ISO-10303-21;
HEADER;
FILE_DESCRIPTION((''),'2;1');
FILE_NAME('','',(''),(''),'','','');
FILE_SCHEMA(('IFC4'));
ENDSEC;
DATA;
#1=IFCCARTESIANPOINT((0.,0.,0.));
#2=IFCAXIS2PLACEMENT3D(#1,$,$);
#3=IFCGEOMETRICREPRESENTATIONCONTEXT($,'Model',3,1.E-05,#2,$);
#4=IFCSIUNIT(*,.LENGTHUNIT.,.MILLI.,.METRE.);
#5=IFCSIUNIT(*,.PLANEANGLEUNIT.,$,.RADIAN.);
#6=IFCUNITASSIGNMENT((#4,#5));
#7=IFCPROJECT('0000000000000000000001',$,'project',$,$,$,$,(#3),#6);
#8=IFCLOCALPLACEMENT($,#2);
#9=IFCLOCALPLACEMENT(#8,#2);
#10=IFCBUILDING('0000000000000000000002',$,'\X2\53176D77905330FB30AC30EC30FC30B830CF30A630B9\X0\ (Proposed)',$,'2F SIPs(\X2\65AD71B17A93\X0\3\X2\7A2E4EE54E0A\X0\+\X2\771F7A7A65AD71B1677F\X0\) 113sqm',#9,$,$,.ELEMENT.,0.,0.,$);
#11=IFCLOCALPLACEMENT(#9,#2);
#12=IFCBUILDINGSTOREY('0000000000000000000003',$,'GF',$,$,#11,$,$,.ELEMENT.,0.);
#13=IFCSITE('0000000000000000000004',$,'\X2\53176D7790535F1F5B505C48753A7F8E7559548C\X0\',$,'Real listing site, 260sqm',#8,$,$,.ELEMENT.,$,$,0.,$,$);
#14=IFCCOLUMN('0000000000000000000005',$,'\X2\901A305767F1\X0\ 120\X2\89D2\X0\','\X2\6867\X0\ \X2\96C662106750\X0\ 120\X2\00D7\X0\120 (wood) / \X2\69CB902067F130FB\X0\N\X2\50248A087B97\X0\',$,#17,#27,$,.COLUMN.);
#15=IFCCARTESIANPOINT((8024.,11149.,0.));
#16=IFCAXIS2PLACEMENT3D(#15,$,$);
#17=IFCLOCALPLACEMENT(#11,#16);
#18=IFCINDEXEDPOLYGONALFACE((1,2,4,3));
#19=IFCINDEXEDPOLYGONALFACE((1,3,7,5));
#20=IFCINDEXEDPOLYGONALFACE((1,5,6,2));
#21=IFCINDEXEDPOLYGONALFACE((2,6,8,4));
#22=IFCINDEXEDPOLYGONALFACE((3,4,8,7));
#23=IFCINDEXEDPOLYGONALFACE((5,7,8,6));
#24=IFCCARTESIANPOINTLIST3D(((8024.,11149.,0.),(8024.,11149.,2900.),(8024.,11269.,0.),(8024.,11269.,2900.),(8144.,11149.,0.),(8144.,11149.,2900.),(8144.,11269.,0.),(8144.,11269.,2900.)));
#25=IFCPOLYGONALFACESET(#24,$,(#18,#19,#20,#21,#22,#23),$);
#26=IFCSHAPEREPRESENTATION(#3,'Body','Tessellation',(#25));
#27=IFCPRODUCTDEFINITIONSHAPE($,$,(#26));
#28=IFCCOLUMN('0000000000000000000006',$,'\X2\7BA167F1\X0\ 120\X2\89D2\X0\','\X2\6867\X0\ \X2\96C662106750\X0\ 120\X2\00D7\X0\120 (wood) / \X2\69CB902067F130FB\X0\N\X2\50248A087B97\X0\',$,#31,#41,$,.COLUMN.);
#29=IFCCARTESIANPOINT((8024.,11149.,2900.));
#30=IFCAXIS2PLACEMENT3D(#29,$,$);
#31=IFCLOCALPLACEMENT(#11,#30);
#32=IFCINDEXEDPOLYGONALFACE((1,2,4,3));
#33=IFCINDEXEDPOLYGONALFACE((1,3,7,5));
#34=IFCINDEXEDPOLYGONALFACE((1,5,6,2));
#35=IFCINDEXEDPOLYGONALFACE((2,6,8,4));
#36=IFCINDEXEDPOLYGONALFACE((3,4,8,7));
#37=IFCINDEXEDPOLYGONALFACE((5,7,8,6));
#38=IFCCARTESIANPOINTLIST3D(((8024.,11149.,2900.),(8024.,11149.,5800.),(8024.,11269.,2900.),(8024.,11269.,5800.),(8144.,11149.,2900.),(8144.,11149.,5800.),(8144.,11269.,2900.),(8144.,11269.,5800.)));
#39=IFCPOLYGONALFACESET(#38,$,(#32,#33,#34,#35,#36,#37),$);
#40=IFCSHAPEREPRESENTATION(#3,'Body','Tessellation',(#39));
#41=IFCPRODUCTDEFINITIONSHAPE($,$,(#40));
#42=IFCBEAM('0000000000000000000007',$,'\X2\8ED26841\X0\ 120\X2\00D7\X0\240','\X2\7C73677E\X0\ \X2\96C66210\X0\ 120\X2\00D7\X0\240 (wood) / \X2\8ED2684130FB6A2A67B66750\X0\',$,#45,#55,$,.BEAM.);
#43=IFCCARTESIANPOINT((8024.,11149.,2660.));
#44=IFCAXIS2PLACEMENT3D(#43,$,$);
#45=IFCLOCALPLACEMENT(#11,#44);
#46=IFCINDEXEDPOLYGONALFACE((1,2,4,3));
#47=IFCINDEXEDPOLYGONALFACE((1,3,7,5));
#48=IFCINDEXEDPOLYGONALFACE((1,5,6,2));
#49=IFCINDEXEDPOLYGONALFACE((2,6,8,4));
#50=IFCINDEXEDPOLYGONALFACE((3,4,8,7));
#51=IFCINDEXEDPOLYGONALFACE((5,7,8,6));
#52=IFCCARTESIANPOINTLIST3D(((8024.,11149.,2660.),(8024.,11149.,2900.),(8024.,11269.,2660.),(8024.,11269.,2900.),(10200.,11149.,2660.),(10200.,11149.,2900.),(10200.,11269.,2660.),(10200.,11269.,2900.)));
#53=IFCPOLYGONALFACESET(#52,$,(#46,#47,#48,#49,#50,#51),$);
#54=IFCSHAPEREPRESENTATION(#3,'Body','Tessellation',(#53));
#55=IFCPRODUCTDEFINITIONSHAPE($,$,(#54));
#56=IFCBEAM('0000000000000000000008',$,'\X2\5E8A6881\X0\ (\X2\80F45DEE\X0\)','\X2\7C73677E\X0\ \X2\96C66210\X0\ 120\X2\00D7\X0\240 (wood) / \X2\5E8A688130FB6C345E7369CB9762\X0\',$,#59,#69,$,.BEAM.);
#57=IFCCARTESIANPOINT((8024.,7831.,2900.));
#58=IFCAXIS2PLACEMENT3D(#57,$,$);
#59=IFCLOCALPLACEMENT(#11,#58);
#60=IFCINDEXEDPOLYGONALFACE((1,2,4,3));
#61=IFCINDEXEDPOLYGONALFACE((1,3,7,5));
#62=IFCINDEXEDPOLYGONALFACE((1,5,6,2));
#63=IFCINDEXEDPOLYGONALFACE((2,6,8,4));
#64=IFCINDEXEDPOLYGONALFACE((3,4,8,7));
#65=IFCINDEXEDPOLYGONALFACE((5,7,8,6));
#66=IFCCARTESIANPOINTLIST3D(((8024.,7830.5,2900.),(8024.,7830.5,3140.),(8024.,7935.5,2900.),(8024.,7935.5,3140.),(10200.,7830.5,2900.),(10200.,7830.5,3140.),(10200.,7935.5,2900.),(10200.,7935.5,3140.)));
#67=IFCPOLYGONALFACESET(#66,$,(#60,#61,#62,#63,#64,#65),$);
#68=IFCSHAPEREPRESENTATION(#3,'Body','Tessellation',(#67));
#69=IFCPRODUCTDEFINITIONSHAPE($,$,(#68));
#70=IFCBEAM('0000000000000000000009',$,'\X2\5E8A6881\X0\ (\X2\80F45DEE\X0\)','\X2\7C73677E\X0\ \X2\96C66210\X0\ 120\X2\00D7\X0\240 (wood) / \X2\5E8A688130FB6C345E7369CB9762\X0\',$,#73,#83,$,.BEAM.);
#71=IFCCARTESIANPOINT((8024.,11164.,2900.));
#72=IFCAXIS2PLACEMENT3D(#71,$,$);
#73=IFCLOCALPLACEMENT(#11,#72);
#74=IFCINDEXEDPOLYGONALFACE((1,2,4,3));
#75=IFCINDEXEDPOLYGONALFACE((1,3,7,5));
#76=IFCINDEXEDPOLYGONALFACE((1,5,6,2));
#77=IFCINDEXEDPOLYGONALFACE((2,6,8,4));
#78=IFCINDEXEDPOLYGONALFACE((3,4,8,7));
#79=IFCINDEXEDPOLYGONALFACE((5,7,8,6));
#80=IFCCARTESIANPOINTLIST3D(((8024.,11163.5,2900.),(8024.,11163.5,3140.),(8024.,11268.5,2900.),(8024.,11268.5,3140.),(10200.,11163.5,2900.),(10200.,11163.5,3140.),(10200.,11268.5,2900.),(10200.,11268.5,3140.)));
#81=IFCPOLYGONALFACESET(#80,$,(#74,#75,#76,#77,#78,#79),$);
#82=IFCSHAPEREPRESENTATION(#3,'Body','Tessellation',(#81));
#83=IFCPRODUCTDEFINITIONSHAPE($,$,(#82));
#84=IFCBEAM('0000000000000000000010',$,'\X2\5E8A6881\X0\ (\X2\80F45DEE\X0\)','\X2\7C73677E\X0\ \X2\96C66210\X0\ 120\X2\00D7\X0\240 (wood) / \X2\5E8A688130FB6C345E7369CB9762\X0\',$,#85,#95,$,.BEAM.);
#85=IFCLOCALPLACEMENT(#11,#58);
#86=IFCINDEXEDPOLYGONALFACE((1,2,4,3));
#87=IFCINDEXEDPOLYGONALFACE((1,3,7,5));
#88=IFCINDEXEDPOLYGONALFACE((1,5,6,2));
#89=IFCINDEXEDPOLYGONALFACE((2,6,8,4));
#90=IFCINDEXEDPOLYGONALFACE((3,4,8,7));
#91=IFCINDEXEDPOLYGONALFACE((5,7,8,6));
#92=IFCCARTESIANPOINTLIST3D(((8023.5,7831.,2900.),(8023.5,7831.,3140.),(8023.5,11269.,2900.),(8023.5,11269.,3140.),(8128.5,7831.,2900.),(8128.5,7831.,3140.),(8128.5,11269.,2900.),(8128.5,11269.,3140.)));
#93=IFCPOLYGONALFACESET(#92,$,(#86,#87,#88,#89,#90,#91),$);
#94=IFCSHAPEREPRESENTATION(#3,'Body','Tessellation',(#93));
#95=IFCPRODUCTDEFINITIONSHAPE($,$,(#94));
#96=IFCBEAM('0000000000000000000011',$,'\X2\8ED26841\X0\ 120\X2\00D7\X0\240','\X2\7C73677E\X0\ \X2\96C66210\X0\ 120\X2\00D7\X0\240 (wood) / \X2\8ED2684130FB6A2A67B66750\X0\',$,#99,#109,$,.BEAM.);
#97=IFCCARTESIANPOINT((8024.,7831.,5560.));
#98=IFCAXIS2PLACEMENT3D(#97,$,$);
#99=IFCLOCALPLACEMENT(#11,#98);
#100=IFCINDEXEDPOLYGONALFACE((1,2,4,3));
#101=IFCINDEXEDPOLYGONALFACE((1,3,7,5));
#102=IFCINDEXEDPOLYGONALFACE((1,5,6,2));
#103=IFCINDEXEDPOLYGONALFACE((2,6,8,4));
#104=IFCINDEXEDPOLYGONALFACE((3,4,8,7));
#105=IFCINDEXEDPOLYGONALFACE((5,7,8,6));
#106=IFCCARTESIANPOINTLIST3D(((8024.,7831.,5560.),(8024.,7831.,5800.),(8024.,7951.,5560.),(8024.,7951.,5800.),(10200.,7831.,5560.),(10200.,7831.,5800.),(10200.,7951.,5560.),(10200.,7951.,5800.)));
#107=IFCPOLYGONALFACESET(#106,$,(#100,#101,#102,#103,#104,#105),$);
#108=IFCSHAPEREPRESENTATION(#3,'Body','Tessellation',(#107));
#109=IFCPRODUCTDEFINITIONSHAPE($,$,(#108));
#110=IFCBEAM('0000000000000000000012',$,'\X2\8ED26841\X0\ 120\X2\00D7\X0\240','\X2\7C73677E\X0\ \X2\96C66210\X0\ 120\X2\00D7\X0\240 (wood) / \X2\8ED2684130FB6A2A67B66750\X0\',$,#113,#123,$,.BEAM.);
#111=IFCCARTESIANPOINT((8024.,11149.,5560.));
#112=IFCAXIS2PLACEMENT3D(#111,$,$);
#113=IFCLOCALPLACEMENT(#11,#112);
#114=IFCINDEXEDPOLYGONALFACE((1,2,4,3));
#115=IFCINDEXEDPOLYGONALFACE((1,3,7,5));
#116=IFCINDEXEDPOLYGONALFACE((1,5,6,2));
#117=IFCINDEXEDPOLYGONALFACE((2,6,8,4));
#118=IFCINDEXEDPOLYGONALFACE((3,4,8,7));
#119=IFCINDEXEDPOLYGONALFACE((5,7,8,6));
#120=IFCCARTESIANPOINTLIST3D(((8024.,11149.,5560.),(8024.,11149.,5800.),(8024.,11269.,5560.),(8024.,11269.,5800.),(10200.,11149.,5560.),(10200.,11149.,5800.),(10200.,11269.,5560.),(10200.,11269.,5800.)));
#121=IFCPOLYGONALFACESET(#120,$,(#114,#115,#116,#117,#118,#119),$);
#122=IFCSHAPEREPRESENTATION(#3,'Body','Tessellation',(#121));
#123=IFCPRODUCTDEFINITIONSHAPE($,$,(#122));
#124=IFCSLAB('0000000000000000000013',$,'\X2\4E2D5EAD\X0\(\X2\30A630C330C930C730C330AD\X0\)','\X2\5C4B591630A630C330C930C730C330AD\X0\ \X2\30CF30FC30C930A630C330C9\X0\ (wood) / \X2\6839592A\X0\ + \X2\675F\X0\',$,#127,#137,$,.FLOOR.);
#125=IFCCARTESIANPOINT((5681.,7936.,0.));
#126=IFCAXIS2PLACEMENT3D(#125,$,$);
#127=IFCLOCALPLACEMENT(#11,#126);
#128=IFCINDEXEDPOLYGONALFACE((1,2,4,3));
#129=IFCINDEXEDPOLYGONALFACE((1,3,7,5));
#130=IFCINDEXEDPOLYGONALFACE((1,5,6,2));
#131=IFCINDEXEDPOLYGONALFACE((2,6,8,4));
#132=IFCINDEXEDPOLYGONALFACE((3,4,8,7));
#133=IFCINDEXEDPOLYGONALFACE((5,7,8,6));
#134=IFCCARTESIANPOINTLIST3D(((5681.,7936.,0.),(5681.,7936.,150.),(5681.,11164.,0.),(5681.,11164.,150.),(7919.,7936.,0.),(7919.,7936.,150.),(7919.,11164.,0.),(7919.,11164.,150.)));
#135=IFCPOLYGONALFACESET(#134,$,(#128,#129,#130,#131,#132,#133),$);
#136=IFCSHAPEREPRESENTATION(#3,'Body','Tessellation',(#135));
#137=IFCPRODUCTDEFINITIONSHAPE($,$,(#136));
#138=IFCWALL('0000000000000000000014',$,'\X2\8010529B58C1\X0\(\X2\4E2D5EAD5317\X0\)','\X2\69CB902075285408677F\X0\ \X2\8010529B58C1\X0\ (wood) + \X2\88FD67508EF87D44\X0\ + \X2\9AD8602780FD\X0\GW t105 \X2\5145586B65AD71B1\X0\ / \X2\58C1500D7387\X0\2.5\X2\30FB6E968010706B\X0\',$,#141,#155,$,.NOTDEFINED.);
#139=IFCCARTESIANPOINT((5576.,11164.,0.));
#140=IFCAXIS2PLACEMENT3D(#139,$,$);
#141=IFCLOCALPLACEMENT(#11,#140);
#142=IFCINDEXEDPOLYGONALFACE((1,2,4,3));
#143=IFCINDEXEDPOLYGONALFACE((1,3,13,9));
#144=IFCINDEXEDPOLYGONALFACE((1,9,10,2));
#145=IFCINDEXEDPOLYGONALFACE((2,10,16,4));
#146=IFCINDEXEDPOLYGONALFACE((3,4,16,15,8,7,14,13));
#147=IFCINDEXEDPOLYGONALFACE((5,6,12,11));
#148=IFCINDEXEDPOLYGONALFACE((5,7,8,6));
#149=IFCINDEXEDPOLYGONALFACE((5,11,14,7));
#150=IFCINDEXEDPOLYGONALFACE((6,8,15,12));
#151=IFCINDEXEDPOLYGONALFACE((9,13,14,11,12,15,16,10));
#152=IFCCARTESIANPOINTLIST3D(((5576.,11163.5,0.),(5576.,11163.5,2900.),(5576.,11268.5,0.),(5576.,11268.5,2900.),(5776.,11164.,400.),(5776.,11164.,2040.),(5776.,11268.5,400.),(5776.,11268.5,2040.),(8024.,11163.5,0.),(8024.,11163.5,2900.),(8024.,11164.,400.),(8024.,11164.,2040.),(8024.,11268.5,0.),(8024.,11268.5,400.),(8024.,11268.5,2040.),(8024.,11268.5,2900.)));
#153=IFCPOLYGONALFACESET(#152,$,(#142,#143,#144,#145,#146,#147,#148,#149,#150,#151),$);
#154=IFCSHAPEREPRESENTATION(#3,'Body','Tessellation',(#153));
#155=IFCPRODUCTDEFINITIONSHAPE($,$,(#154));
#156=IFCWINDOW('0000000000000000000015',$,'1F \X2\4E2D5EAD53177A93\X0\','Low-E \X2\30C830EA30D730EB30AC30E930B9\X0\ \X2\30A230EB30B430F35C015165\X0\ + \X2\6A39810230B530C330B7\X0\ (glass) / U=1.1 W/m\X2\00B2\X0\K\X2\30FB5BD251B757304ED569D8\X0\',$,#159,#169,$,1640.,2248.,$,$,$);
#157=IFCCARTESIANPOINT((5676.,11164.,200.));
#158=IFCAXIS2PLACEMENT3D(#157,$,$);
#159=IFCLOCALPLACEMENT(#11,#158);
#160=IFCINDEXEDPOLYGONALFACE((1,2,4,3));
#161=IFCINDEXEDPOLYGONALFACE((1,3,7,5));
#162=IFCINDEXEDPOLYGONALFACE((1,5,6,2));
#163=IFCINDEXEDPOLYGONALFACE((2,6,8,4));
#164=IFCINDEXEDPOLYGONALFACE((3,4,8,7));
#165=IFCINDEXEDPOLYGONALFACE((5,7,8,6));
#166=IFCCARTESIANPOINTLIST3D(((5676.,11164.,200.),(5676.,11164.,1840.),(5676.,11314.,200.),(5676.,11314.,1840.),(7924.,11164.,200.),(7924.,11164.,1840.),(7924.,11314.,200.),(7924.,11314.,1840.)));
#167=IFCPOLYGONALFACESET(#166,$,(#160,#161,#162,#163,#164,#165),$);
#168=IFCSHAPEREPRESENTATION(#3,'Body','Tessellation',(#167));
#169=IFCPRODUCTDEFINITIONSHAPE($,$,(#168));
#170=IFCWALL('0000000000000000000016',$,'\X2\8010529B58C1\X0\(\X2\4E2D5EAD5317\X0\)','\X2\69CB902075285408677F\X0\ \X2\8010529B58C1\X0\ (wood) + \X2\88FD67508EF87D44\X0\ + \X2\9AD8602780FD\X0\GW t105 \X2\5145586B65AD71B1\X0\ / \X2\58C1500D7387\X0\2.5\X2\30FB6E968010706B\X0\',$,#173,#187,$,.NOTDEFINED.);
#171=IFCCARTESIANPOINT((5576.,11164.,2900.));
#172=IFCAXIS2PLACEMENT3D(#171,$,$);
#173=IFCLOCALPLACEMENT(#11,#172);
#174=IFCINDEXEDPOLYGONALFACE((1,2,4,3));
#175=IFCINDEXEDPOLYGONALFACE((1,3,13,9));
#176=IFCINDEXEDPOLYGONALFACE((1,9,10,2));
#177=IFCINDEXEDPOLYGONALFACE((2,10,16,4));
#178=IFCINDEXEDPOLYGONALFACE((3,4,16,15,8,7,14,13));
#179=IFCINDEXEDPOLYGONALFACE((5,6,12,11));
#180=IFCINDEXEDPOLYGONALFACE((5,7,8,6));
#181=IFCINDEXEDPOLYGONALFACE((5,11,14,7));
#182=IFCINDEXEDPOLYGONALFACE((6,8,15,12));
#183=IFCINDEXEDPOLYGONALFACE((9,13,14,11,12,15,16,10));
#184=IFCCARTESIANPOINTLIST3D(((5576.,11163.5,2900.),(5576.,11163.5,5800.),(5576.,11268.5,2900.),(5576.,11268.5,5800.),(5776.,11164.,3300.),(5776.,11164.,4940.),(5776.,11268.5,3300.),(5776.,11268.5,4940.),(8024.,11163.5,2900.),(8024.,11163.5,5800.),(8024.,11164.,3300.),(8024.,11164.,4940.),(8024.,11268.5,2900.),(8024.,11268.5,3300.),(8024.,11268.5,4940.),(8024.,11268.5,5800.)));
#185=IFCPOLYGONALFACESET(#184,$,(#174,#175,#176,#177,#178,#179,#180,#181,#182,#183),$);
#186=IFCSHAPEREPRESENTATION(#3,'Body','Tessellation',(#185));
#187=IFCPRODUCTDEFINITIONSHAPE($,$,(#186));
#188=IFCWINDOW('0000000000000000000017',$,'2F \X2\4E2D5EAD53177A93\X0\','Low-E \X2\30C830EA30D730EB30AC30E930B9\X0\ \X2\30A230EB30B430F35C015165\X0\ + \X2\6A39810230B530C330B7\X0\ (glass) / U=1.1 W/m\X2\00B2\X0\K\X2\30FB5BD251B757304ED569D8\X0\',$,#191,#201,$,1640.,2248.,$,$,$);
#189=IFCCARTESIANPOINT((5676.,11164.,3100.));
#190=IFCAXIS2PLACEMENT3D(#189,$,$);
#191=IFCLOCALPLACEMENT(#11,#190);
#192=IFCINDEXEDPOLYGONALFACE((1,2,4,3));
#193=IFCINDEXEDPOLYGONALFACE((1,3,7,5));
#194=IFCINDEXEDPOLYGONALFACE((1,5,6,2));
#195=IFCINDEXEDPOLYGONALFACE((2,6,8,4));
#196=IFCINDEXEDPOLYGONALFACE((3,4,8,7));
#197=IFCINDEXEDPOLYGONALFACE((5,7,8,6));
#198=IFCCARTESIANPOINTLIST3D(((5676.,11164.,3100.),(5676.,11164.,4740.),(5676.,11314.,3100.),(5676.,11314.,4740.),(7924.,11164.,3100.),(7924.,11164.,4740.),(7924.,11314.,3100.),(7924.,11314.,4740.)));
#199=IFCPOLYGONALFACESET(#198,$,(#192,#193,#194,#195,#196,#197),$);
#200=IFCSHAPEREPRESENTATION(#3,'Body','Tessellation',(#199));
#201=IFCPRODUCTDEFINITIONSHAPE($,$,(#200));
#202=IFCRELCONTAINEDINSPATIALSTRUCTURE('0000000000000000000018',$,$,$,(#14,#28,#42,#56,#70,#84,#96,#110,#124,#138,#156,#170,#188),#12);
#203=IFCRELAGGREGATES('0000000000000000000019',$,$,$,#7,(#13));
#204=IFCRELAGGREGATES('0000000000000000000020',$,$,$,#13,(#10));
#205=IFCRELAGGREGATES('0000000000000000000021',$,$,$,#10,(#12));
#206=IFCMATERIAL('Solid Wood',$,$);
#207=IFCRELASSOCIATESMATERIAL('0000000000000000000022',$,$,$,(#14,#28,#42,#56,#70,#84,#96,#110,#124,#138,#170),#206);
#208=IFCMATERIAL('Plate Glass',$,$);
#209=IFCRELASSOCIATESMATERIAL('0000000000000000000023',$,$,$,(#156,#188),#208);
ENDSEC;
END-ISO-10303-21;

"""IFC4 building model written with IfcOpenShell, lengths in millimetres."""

from ifc_helpers import new_model, si_unit, frame, frame_2d, origin, place, context, project, spatial, rectangle, extrude, material, element, fill, save


model = new_model("IFC4")

# Units and contexts
model_context = context("Model", 3, precision=1e-05, world=origin())
ifc_project = project(units=[si_unit("LENGTHUNIT", "METRE", prefix="MILLI"), si_unit("PLANEANGLEUNIT", "RADIAN")], contexts=[model_context])

# Site, building, storey
site_placement = place(None, origin())
site = spatial("IfcSite", under=ifc_project, at=site_placement, Name="北海道弟子屈町美留和", ObjectType="Real listing site, 260sqm", CompositionType="ELEMENT", RefElevation=0.0)
building_placement = place(site_placement, origin())
building = spatial("IfcBuilding", under=site, at=building_placement, Name="北海道・ガレージハウス (Proposed)", ObjectType="2F SIPs(断熱窓3種以上+真空断熱板) 113sqm", CompositionType="ELEMENT", ElevationOfRefHeight=0.0, ElevationOfTerrain=0.0)
storey_placement = place(building_placement, origin())
storey = spatial("IfcBuildingStorey", under=building, at=storey_placement, Name="GF", CompositionType="ELEMENT", Elevation=0.0)

# Columns
ifc_material_1 = material(Name="Solid Wood")
column_1_placement = place(storey_placement, frame((8024.0, 11149.0, 0.0)))
element("IfcColumn", 1, at=column_1_placement, inside=storey, material=ifc_material_1, Name="通し柱 120角", Description="桧 集成材 120×120 (wood) / 構造柱・N値計算", PredefinedType="COLUMN", context=model_context, shape_type="SweptSolid", body=[
    extrude(rectangle(XDim=120.0, YDim=120.0, at=frame_2d((60.0, 60.0))), frame((8024.0, 11149.0, 0.0)), (0.0, 0.0, 1.0), 2900.0),
])
column_2_placement = place(storey_placement, frame((8024.0, 11149.0, 2900.0)))
element("IfcColumn", 2, at=column_2_placement, inside=storey, material=ifc_material_1, Name="管柱 120角", Description="桧 集成材 120×120 (wood) / 構造柱・N値計算", PredefinedType="COLUMN", context=model_context, shape_type="SweptSolid", body=[
    extrude(rectangle(XDim=120.0, YDim=120.0, at=frame_2d((60.0, 60.0))), frame((8024.0, 11149.0, 2900.0)), (0.0, 0.0, 1.0), 2900.0),
])

# Beams
beam_1_placement = place(storey_placement, frame((8024.0, 11149.0, 2660.0)))
element("IfcBeam", 3, at=beam_1_placement, inside=storey, material=ifc_material_1, Name="軒桁 120×240", Description="米松 集成 120×240 (wood) / 軒桁・横架材", PredefinedType="BEAM", context=model_context, shape_type="SweptSolid", body=[
    extrude(rectangle(XDim=2176.0, YDim=120.0, at=frame_2d((1088.0, 60.0))), frame((8024.0, 11149.0, 2660.0)), (0.0, 0.0, 1.0), 240.0),
])
beam_2_placement = place(storey_placement, frame((8024.0, 7831.0, 2900.0)))
element("IfcBeam", 4, at=beam_2_placement, inside=storey, material=ifc_material_1, Name="床梁 (胴差)", Description="米松 集成 120×240 (wood) / 床梁・水平構面", PredefinedType="BEAM", context=model_context, shape_type="SweptSolid", body=[
    extrude(rectangle(XDim=2176.0, YDim=105.0, at=frame_2d((1088.0, 52.0))), frame((8024.0, 7831.0, 2900.0)), (0.0, 0.0, 1.0), 240.0),
])
beam_3_placement = place(storey_placement, frame((8024.0, 11164.0, 2900.0)))
element("IfcBeam", 5, at=beam_3_placement, inside=storey, material=ifc_material_1, Name="床梁 (胴差)", Description="米松 集成 120×240 (wood) / 床梁・水平構面", PredefinedType="BEAM", context=model_context, shape_type="SweptSolid", body=[
    extrude(rectangle(XDim=2176.0, YDim=105.0, at=frame_2d((1088.0, 52.0))), frame((8024.0, 11164.0, 2900.0)), (0.0, 0.0, 1.0), 240.0),
])
beam_4_placement = place(storey_placement, frame((8024.0, 7831.0, 2900.0)))
element("IfcBeam", 6, at=beam_4_placement, inside=storey, material=ifc_material_1, Name="床梁 (胴差)", Description="米松 集成 120×240 (wood) / 床梁・水平構面", PredefinedType="BEAM", context=model_context, shape_type="SweptSolid", body=[
    extrude(rectangle(XDim=105.0, YDim=3438.0, at=frame_2d((52.0, 1719.0))), frame((8024.0, 7831.0, 2900.0)), (0.0, 0.0, 1.0), 240.0),
])
beam_5_placement = place(storey_placement, frame((8024.0, 7831.0, 5560.0)))
element("IfcBeam", 7, at=beam_5_placement, inside=storey, material=ifc_material_1, Name="軒桁 120×240", Description="米松 集成 120×240 (wood) / 軒桁・横架材", PredefinedType="BEAM", context=model_context, shape_type="SweptSolid", body=[
    extrude(rectangle(XDim=2176.0, YDim=120.0, at=frame_2d((1088.0, 60.0))), frame((8024.0, 7831.0, 5560.0)), (0.0, 0.0, 1.0), 240.0),
])
beam_6_placement = place(storey_placement, frame((8024.0, 11149.0, 5560.0)))
element("IfcBeam", 8, at=beam_6_placement, inside=storey, material=ifc_material_1, Name="軒桁 120×240", Description="米松 集成 120×240 (wood) / 軒桁・横架材", PredefinedType="BEAM", context=model_context, shape_type="SweptSolid", body=[
    extrude(rectangle(XDim=2176.0, YDim=120.0, at=frame_2d((1088.0, 60.0))), frame((8024.0, 11149.0, 5560.0)), (0.0, 0.0, 1.0), 240.0),
])

# Slab
slab_placement = place(storey_placement, frame((5681.0, 7936.0, 0.0)))
element("IfcSlab", 9, at=slab_placement, inside=storey, material=ifc_material_1, Name="中庭(ウッドデッキ)", Description="屋外ウッドデッキ ハードウッド (wood) / 根太 + 束", PredefinedType="FLOOR", context=model_context, shape_type="SweptSolid", body=[
    extrude(rectangle(XDim=2238.0, YDim=3228.0, at=frame_2d((1119.0, 1614.0))), frame((5681.0, 7936.0, 0.0)), (0.0, 0.0, 1.0), 150.0),
])

# Wall, opening, window
wall_1_placement = place(storey_placement, frame((5576.0, 11164.0, 0.0)))
wall_1 = element("IfcWall", 10, at=wall_1_placement, inside=storey, material=ifc_material_1, Name="耐力壁(中庭北)", Description="構造用合板 耐力壁 (wood) + 製材軸組 + 高性能GW t105 充填断熱 / 壁倍率2.5・準耐火", PredefinedType="NOTDEFINED", context=model_context, shape_type="SweptSolid", body=[
    extrude(rectangle(XDim=2448.0, YDim=105.0, at=frame_2d((1224.0, 52.0))), frame((5576.0, 11164.0, 0.0)), (0.0, 0.0, 1.0), 2900.0),
])
opening_1_placement = place(storey_placement, frame((5676.0, 11164.0, 200.0)))
opening_1 = element("IfcOpeningElement", 11, at=opening_1_placement, cuts=wall_1, PredefinedType="NOTDEFINED", context=model_context, shape_type="SweptSolid", body=[
    extrude(rectangle(XDim=2248.0, YDim=150.0, at=frame_2d((1124.0, 75.0))), frame((5676.0, 11164.0, 200.0)), (0.0, 0.0, 1.0), 1640.0),
])
ifc_material_2 = material(Name="Plate Glass")
window_1_placement = place(storey_placement, frame((5676.0, 11164.0, 200.0)))
window_1 = element("IfcWindow", 12, at=window_1_placement, inside=storey, material=ifc_material_2, Name="1F 中庭北窓", Description="Low-E トリプルガラス アルゴン封入 + 樹脂サッシ (glass) / U=1.1 W/m²K・寒冷地仕様", OverallHeight=1640.0, OverallWidth=2248.0, context=model_context, shape_type="SweptSolid", body=[
    extrude(rectangle(XDim=2248.0, YDim=150.0, at=frame_2d((1124.0, 75.0))), frame((5676.0, 11164.0, 200.0)), (0.0, 0.0, 1.0), 1640.0),
])
fill(opening_1, window_1)

# Wall, opening, window
wall_2_placement = place(storey_placement, frame((5576.0, 11164.0, 2900.0)))
wall_2 = element("IfcWall", 13, at=wall_2_placement, inside=storey, material=ifc_material_1, Name="耐力壁(中庭北)", Description="構造用合板 耐力壁 (wood) + 製材軸組 + 高性能GW t105 充填断熱 / 壁倍率2.5・準耐火", PredefinedType="NOTDEFINED", context=model_context, shape_type="SweptSolid", body=[
    extrude(rectangle(XDim=2448.0, YDim=105.0, at=frame_2d((1224.0, 52.0))), frame((5576.0, 11164.0, 2900.0)), (0.0, 0.0, 1.0), 2900.0),
])
opening_2_placement = place(storey_placement, frame((5676.0, 11164.0, 3100.0)))
opening_2 = element("IfcOpeningElement", 14, at=opening_2_placement, cuts=wall_2, PredefinedType="NOTDEFINED", context=model_context, shape_type="SweptSolid", body=[
    extrude(rectangle(XDim=2248.0, YDim=150.0, at=frame_2d((1124.0, 75.0))), frame((5676.0, 11164.0, 3100.0)), (0.0, 0.0, 1.0), 1640.0),
])
window_2_placement = place(storey_placement, frame((5676.0, 11164.0, 3100.0)))
window_2 = element("IfcWindow", 15, at=window_2_placement, inside=storey, material=ifc_material_2, Name="2F 中庭北窓", Description="Low-E トリプルガラス アルゴン封入 + 樹脂サッシ (glass) / U=1.1 W/m²K・寒冷地仕様", OverallHeight=1640.0, OverallWidth=2248.0, context=model_context, shape_type="SweptSolid", body=[
    extrude(rectangle(XDim=2248.0, YDim=150.0, at=frame_2d((1124.0, 75.0))), frame((5676.0, 11164.0, 3100.0)), (0.0, 0.0, 1.0), 1640.0),
])
fill(opening_2, window_2)

save(model, "model.ifc")
